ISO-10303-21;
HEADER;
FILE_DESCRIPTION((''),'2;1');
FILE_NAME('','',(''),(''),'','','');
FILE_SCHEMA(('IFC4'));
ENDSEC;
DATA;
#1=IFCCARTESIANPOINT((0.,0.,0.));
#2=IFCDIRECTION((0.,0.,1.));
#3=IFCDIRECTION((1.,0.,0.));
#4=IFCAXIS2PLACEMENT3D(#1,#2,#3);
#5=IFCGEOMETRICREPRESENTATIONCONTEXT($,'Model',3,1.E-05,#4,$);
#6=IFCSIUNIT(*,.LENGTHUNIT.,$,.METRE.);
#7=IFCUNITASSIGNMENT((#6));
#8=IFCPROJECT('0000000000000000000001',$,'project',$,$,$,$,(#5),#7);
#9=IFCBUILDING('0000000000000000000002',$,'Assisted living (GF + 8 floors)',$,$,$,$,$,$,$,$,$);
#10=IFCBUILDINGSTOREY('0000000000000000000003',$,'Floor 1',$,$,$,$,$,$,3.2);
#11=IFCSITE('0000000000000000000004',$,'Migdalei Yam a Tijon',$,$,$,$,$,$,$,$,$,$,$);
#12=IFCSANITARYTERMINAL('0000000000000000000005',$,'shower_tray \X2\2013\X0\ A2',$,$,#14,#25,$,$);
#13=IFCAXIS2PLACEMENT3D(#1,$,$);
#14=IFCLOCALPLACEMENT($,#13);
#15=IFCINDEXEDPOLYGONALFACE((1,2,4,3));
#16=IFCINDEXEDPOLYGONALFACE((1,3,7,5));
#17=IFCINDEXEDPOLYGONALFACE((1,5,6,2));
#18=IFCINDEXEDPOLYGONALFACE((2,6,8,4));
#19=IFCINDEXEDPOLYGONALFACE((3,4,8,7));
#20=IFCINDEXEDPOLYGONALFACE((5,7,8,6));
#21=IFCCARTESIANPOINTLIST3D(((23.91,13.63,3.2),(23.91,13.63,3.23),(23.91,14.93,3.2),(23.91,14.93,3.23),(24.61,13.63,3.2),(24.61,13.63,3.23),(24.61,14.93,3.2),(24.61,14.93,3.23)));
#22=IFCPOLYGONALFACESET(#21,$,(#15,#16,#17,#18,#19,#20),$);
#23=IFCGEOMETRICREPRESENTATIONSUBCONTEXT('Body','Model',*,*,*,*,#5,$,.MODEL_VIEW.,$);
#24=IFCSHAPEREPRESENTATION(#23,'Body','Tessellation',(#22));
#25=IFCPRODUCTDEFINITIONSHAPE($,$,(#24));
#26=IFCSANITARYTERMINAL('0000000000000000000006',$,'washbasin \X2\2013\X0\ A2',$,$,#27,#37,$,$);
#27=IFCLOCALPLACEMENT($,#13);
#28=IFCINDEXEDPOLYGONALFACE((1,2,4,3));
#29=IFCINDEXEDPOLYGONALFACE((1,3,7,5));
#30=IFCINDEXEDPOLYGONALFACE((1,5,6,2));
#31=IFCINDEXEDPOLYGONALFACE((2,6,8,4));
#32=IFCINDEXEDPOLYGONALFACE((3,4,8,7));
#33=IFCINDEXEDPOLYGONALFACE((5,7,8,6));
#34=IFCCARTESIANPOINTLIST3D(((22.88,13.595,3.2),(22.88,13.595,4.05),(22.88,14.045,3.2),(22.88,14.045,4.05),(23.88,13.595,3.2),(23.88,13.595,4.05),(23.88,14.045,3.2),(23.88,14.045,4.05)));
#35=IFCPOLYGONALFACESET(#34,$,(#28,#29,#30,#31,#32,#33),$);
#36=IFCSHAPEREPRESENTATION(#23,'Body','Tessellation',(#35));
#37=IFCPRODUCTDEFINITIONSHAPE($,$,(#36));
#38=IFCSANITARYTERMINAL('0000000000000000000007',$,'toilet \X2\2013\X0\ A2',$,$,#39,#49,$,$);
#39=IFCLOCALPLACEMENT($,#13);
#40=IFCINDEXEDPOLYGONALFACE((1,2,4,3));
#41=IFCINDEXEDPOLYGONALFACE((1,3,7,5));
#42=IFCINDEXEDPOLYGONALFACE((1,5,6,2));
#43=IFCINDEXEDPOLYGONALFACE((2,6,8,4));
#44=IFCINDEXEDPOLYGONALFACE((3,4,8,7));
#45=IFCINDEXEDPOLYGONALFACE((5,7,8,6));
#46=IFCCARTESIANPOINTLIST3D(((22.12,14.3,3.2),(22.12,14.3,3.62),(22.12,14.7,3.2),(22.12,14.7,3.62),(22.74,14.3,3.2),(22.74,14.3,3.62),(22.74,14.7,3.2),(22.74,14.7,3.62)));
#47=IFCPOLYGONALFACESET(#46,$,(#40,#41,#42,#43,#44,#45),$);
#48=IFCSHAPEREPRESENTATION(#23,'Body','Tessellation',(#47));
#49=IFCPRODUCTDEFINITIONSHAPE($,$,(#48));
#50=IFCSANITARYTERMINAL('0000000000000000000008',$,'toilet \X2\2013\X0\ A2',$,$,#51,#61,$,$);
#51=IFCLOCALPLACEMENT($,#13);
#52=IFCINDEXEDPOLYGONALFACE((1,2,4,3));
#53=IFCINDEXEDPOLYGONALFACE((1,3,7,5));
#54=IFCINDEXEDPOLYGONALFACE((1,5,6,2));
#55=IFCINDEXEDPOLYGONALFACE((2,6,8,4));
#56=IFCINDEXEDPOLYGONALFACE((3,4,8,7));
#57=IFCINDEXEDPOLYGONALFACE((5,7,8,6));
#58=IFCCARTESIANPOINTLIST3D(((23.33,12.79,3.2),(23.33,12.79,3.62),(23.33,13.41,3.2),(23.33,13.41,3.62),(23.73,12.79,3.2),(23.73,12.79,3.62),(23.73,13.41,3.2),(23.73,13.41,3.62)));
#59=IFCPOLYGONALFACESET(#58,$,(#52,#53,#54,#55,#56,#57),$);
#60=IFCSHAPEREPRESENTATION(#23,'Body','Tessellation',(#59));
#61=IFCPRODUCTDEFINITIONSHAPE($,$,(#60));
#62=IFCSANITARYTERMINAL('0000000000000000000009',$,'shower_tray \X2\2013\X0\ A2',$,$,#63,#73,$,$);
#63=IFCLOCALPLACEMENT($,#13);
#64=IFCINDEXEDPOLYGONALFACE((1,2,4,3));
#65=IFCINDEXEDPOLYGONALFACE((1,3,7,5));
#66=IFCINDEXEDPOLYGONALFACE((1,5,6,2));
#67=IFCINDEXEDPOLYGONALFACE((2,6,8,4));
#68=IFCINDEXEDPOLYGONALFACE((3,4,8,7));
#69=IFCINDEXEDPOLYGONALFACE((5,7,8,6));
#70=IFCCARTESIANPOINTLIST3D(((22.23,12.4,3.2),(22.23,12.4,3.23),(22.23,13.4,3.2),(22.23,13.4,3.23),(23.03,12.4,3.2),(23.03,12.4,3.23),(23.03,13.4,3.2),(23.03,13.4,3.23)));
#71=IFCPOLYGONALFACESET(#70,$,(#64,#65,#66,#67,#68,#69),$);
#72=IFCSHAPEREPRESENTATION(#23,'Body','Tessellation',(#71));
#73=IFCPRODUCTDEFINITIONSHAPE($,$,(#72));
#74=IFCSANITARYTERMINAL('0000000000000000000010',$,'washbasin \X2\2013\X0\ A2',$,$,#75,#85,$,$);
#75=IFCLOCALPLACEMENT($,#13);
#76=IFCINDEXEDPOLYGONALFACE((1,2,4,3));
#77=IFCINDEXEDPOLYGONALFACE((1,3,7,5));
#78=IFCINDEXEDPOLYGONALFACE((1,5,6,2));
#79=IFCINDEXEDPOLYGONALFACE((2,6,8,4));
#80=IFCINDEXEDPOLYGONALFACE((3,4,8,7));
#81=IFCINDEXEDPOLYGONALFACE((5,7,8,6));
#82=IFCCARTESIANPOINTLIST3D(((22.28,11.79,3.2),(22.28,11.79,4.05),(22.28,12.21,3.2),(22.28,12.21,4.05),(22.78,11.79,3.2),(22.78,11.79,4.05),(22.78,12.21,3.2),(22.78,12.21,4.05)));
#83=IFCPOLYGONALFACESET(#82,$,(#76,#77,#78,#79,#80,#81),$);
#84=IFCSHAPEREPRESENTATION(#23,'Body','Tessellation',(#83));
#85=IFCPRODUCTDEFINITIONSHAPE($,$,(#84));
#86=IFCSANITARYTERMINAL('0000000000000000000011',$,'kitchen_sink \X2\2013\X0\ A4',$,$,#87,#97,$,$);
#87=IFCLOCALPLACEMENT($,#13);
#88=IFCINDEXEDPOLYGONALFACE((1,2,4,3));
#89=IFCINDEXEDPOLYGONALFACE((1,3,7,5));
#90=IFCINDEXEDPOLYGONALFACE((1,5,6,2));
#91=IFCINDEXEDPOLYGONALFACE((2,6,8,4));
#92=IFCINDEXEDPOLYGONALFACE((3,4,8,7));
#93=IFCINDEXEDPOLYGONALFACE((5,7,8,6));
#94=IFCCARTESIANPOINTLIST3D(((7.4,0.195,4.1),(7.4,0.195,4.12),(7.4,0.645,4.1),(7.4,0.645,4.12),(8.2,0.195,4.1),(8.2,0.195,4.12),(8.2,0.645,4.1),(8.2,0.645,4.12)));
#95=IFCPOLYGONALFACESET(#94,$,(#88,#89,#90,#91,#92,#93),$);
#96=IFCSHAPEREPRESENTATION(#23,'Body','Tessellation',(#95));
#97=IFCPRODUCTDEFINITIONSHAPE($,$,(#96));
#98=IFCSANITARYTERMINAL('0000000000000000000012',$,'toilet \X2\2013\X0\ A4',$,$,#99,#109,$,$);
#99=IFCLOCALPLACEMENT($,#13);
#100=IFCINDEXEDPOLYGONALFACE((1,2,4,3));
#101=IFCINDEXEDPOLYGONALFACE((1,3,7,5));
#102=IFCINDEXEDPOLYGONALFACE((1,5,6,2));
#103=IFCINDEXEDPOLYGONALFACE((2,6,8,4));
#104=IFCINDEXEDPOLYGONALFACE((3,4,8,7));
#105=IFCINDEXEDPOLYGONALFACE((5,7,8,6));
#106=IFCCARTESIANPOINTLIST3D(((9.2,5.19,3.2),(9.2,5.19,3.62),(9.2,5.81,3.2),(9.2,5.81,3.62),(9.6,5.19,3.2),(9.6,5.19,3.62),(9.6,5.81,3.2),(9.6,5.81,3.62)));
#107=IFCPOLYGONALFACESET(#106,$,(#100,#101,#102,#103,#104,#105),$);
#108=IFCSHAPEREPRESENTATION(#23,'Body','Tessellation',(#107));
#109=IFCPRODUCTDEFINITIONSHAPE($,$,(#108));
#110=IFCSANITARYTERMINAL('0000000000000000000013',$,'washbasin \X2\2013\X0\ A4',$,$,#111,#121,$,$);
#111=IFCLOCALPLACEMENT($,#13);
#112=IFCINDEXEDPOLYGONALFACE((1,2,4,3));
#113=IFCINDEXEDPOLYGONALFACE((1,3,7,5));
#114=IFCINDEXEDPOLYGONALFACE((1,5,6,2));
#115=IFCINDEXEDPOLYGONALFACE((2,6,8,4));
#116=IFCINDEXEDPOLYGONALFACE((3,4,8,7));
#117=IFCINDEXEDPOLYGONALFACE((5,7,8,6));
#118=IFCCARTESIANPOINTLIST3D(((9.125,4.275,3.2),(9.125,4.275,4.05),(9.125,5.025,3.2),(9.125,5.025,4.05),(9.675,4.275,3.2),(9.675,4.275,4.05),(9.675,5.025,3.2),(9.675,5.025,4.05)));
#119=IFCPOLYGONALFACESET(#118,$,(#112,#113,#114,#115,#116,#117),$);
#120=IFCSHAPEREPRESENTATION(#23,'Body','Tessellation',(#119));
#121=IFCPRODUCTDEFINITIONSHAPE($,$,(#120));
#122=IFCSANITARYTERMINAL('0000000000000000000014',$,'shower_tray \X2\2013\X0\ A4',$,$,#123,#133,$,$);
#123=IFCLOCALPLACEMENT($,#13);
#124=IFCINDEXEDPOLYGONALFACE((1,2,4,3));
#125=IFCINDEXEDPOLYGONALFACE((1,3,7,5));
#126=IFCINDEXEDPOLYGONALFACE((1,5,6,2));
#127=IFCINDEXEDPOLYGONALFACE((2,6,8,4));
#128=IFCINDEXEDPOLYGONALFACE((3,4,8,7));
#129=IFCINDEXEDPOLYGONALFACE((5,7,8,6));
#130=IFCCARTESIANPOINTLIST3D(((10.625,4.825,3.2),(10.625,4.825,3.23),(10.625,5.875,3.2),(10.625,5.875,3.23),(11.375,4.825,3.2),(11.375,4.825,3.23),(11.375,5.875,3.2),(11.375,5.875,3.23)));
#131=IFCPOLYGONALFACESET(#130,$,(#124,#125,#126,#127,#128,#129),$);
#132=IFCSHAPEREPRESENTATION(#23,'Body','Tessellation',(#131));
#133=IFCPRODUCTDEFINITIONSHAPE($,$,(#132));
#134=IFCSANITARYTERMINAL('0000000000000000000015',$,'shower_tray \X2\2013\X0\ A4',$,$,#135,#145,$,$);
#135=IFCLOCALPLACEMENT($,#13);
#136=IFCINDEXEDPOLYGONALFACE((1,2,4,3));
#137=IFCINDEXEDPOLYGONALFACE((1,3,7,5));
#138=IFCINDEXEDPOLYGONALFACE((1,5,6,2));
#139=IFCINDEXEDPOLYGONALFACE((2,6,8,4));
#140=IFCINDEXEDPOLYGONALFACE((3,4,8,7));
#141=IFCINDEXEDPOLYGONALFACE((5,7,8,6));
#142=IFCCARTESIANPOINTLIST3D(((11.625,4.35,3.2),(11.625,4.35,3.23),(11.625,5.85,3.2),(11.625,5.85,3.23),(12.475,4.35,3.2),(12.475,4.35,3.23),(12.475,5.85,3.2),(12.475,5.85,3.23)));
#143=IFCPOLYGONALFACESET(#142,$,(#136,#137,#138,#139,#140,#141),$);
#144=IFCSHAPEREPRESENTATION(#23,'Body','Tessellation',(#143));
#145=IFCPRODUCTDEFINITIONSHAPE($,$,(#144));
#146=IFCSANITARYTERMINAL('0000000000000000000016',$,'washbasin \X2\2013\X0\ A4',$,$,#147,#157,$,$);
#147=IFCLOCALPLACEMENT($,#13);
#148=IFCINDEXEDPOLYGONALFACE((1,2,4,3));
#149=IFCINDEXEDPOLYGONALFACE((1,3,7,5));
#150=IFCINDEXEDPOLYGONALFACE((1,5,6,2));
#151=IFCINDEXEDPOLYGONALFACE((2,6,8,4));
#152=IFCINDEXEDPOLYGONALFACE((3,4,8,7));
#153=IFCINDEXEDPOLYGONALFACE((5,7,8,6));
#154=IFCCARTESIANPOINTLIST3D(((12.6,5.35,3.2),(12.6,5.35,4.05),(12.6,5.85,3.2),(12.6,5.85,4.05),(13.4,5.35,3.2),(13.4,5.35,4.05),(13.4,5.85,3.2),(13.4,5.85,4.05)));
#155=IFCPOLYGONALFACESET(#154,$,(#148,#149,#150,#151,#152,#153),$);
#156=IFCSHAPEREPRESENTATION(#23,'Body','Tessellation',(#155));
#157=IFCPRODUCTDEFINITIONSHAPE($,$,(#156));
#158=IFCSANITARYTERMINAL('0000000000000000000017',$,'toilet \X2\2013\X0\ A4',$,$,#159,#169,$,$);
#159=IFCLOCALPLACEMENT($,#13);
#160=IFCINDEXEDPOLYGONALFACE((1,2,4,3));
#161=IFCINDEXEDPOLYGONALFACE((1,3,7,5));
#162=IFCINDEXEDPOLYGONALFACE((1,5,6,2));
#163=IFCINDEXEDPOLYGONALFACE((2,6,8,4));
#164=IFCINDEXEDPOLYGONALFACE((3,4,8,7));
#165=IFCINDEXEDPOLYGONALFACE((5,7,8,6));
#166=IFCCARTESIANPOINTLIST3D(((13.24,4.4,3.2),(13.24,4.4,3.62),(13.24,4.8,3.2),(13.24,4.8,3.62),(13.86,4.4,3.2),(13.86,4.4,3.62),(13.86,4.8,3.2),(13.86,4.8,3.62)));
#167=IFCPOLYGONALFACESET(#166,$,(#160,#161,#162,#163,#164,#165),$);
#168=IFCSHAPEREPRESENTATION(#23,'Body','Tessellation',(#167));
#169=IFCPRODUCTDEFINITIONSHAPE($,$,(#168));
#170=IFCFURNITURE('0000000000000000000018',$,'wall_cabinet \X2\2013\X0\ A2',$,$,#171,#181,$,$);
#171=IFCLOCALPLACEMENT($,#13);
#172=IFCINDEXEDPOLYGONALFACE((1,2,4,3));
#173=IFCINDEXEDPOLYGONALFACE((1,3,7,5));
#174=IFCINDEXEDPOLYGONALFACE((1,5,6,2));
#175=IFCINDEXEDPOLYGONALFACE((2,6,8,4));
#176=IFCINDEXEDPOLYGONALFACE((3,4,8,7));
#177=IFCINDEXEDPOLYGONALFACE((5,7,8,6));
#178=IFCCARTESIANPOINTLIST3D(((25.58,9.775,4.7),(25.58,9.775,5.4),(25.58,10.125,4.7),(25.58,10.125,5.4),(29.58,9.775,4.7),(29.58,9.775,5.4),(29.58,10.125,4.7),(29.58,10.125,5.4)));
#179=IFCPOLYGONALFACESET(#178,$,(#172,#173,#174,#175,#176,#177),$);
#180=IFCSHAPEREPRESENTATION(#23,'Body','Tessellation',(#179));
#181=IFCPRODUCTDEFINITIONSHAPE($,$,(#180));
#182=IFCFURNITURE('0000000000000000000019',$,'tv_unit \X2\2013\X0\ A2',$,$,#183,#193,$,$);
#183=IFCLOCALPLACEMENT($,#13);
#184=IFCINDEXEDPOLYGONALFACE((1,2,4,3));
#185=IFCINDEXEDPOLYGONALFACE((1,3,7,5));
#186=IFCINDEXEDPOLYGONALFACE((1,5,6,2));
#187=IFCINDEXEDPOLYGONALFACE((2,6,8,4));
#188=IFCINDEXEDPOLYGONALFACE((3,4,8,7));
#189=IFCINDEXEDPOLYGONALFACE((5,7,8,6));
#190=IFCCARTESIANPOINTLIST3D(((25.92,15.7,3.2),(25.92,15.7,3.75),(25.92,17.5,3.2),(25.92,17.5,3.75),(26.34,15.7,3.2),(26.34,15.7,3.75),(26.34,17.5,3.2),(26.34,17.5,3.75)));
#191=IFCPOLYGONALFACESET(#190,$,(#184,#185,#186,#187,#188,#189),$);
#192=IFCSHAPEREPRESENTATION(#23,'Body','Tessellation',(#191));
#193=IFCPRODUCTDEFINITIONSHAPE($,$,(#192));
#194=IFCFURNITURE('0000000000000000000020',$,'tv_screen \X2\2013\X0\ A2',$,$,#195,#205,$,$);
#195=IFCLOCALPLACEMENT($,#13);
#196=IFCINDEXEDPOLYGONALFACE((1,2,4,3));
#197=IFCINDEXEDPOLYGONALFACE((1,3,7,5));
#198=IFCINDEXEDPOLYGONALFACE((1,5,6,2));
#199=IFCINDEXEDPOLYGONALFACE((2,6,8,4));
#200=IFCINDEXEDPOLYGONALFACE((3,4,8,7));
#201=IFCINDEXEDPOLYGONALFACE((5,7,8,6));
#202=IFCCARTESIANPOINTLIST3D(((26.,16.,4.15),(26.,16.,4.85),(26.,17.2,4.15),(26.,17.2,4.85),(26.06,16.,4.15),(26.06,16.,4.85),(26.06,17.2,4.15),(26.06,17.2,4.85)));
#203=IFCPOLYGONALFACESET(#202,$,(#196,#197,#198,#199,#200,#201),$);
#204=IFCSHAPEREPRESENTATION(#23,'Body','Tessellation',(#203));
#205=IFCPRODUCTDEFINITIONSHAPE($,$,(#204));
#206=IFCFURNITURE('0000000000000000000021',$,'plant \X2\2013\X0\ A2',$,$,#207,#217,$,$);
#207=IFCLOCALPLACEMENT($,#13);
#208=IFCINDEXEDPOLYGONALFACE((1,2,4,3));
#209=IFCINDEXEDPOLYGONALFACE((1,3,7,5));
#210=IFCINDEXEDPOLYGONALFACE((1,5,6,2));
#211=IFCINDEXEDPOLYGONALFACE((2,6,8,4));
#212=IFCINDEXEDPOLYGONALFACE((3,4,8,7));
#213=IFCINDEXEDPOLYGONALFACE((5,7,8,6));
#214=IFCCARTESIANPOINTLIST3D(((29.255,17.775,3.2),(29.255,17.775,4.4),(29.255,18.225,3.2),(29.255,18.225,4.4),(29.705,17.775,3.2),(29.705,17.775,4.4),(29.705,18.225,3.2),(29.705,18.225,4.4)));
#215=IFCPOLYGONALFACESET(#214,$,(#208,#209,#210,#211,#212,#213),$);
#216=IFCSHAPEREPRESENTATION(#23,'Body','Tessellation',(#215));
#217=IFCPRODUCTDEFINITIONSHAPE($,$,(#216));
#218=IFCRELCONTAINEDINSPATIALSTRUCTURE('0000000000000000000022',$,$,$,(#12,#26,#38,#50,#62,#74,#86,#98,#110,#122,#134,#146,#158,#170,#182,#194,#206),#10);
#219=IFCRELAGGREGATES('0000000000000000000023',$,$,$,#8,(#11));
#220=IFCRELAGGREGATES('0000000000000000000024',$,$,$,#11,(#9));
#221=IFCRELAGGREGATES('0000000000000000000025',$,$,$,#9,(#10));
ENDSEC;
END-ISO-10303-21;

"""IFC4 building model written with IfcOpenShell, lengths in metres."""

from ifc_helpers import new_model, si_unit, frame, origin_with_axes, context, subcontext, project, spatial, line, indexed_curve, outline, extrude, element, save


model = new_model("IFC4")

# Units and contexts
model_context = context("Model", 3, precision=1e-05, world=origin_with_axes())
body_context = subcontext(model_context, "Body", "Model", "MODEL_VIEW")
ifc_project = project(units=[si_unit("LENGTHUNIT", "METRE")], contexts=[model_context])

# Site, building, storey
site = spatial("IfcSite", under=ifc_project, Name="Migdalei Yam a Tijon")
building = spatial("IfcBuilding", under=site, Name="Assisted living (GF + 8 floors)")
storey = spatial("IfcBuildingStorey", under=building, Name="Floor 1", Elevation=3.2)

# Sanitary terminals
element("IfcSanitaryTerminal", 1, inside=storey, Name="shower_tray – A2", context=body_context, shape_type="SweptSolid", body=[
    extrude(outline(indexed_curve([(0.0, 0.0), (0.7, 0.0), (0.7, 1.3), (0.0, 1.3)], segments=[line(1, 2, 3, 4, 1)])), frame((23.91, 13.63, 3.2), z_axis=(0.0, 0.0, 1.0), x_axis=(1.0, 0.0, 0.0)), (0.0, 0.0, 1.0), 0.03),
])
element("IfcSanitaryTerminal", 2, inside=storey, Name="washbasin – A2", context=body_context, shape_type="SweptSolid", body=[
    extrude(outline(indexed_curve([(0.0, 0.0), (1.0, 0.0), (1.0, 0.45), (0.0, 0.45)], segments=[line(1, 2, 3, 4, 1)])), frame((22.88, 13.595, 3.2), z_axis=(0.0, 0.0, 1.0), x_axis=(1.0, 0.0, 0.0)), (0.0, 0.0, 1.0), 0.85),
])
element("IfcSanitaryTerminal", 3, inside=storey, Name="toilet – A2", context=body_context, shape_type="SweptSolid", body=[
    extrude(outline(indexed_curve([(0.0, 0.0), (0.62, 0.0), (0.62, 0.4), (0.0, 0.4)], segments=[line(1, 2, 3, 4, 1)])), frame((22.12, 14.3, 3.2), z_axis=(0.0, 0.0, 1.0), x_axis=(1.0, 0.0, 0.0)), (0.0, 0.0, 1.0), 0.42),
])
element("IfcSanitaryTerminal", 4, inside=storey, Name="toilet – A2", context=body_context, shape_type="SweptSolid", body=[
    extrude(outline(indexed_curve([(0.0, 0.0), (0.4, 0.0), (0.4, 0.62), (0.0, 0.62)], segments=[line(1, 2, 3, 4, 1)])), frame((23.33, 12.79, 3.2), z_axis=(0.0, 0.0, 1.0), x_axis=(1.0, 0.0, 0.0)), (0.0, 0.0, 1.0), 0.42),
])
element("IfcSanitaryTerminal", 5, inside=storey, Name="shower_tray – A2", context=body_context, shape_type="SweptSolid", body=[
    extrude(outline(indexed_curve([(0.0, 0.0), (0.8, 0.0), (0.8, 1.0), (0.0, 1.0)], segments=[line(1, 2, 3, 4, 1)])), frame((22.23, 12.4, 3.2), z_axis=(0.0, 0.0, 1.0), x_axis=(1.0, 0.0, 0.0)), (0.0, 0.0, 1.0), 0.03),
])
element("IfcSanitaryTerminal", 6, inside=storey, Name="washbasin – A2", context=body_context, shape_type="SweptSolid", body=[
    extrude(outline(indexed_curve([(0.0, 0.0), (0.5, 0.0), (0.5, 0.42), (0.0, 0.42)], segments=[line(1, 2, 3, 4, 1)])), frame((22.28, 11.79, 3.2), z_axis=(0.0, 0.0, 1.0), x_axis=(1.0, 0.0, 0.0)), (0.0, 0.0, 1.0), 0.85),
])
element("IfcSanitaryTerminal", 7, inside=storey, Name="kitchen_sink – A4", context=body_context, shape_type="SweptSolid", body=[
    extrude(outline(indexed_curve([(0.0, 0.0), (0.8, 0.0), (0.8, 0.45), (0.0, 0.45)], segments=[line(1, 2, 3, 4, 1)])), frame((7.4, 0.195, 4.1), z_axis=(0.0, 0.0, 1.0), x_axis=(1.0, 0.0, 0.0)), (0.0, 0.0, 1.0), 0.02),
])
element("IfcSanitaryTerminal", 8, inside=storey, Name="toilet – A4", context=body_context, shape_type="SweptSolid", body=[
    extrude(outline(indexed_curve([(0.0, 0.0), (0.4, 0.0), (0.4, 0.62), (0.0, 0.62)], segments=[line(1, 2, 3, 4, 1)])), frame((9.2, 5.19, 3.2), z_axis=(0.0, 0.0, 1.0), x_axis=(1.0, 0.0, 0.0)), (0.0, 0.0, 1.0), 0.42),
])
element("IfcSanitaryTerminal", 9, inside=storey, Name="washbasin – A4", context=body_context, shape_type="SweptSolid", body=[
    extrude(outline(indexed_curve([(0.0, 0.0), (0.55, 0.0), (0.55, 0.75), (0.0, 0.75)], segments=[line(1, 2, 3, 4, 1)])), frame((9.125, 4.275, 3.2), z_axis=(0.0, 0.0, 1.0), x_axis=(1.0, 0.0, 0.0)), (0.0, 0.0, 1.0), 0.85),
])
element("IfcSanitaryTerminal", 10, inside=storey, Name="shower_tray – A4", context=body_context, shape_type="SweptSolid", body=[
    extrude(outline(indexed_curve([(0.0, 0.0), (0.75, 0.0), (0.75, 1.05), (0.0, 1.05)], segments=[line(1, 2, 3, 4, 1)])), frame((10.625, 4.825, 3.2), z_axis=(0.0, 0.0, 1.0), x_axis=(1.0, 0.0, 0.0)), (0.0, 0.0, 1.0), 0.03),
])
element("IfcSanitaryTerminal", 11, inside=storey, Name="shower_tray – A4", context=body_context, shape_type="SweptSolid", body=[
    extrude(outline(indexed_curve([(0.0, 0.0), (0.85, 0.0), (0.85, 1.5), (0.0, 1.5)], segments=[line(1, 2, 3, 4, 1)])), frame((11.625, 4.35, 3.2), z_axis=(0.0, 0.0, 1.0), x_axis=(1.0, 0.0, 0.0)), (0.0, 0.0, 1.0), 0.03),
])
element("IfcSanitaryTerminal", 12, inside=storey, Name="washbasin – A4", context=body_context, shape_type="SweptSolid", body=[
    extrude(outline(indexed_curve([(0.0, 0.0), (0.8, 0.0), (0.8, 0.5), (0.0, 0.5)], segments=[line(1, 2, 3, 4, 1)])), frame((12.6, 5.35, 3.2), z_axis=(0.0, 0.0, 1.0), x_axis=(1.0, 0.0, 0.0)), (0.0, 0.0, 1.0), 0.85),
])
element("IfcSanitaryTerminal", 13, inside=storey, Name="toilet – A4", context=body_context, shape_type="SweptSolid", body=[
    extrude(outline(indexed_curve([(0.0, 0.0), (0.62, 0.0), (0.62, 0.4), (0.0, 0.4)], segments=[line(1, 2, 3, 4, 1)])), frame((13.24, 4.4, 3.2), z_axis=(0.0, 0.0, 1.0), x_axis=(1.0, 0.0, 0.0)), (0.0, 0.0, 1.0), 0.42),
])

# Furniture
element("IfcFurniture", 14, inside=storey, Name="wall_cabinet – A2", context=body_context, shape_type="SweptSolid", body=[
    extrude(outline(indexed_curve([(0.0, 0.0), (4.0, 0.0), (4.0, 0.35), (0.0, 0.35)], segments=[line(1, 2, 3, 4, 1)])), frame((25.58, 9.775, 4.7), z_axis=(0.0, 0.0, 1.0), x_axis=(1.0, 0.0, 0.0)), (0.0, 0.0, 1.0), 0.7),
])
element("IfcFurniture", 15, inside=storey, Name="tv_unit – A2", context=body_context, shape_type="SweptSolid", body=[
    extrude(outline(indexed_curve([(0.0, 0.0), (0.42, 0.0), (0.42, 1.8), (0.0, 1.8)], segments=[line(1, 2, 3, 4, 1)])), frame((25.92, 15.7, 3.2), z_axis=(0.0, 0.0, 1.0), x_axis=(1.0, 0.0, 0.0)), (0.0, 0.0, 1.0), 0.55),
])
element("IfcFurniture", 16, inside=storey, Name="tv_screen – A2", context=body_context, shape_type="SweptSolid", body=[
    extrude(outline(indexed_curve([(0.0, 0.0), (0.06, 0.0), (0.06, 1.2), (0.0, 1.2)], segments=[line(1, 2, 3, 4, 1)])), frame((26.0, 16.0, 4.15), z_axis=(0.0, 0.0, 1.0), x_axis=(1.0, 0.0, 0.0)), (0.0, 0.0, 1.0), 0.7),
])
element("IfcFurniture", 17, inside=storey, Name="plant – A2", context=body_context, shape_type="SweptSolid", body=[
    extrude(outline(indexed_curve([(0.0, 0.0), (0.45, 0.0), (0.45, 0.45), (0.0, 0.45)], segments=[line(1, 2, 3, 4, 1)])), frame((29.255, 17.775, 3.2), z_axis=(0.0, 0.0, 1.0), x_axis=(1.0, 0.0, 0.0)), (0.0, 0.0, 1.0), 1.2),
])

save(model, "model.ifc")
